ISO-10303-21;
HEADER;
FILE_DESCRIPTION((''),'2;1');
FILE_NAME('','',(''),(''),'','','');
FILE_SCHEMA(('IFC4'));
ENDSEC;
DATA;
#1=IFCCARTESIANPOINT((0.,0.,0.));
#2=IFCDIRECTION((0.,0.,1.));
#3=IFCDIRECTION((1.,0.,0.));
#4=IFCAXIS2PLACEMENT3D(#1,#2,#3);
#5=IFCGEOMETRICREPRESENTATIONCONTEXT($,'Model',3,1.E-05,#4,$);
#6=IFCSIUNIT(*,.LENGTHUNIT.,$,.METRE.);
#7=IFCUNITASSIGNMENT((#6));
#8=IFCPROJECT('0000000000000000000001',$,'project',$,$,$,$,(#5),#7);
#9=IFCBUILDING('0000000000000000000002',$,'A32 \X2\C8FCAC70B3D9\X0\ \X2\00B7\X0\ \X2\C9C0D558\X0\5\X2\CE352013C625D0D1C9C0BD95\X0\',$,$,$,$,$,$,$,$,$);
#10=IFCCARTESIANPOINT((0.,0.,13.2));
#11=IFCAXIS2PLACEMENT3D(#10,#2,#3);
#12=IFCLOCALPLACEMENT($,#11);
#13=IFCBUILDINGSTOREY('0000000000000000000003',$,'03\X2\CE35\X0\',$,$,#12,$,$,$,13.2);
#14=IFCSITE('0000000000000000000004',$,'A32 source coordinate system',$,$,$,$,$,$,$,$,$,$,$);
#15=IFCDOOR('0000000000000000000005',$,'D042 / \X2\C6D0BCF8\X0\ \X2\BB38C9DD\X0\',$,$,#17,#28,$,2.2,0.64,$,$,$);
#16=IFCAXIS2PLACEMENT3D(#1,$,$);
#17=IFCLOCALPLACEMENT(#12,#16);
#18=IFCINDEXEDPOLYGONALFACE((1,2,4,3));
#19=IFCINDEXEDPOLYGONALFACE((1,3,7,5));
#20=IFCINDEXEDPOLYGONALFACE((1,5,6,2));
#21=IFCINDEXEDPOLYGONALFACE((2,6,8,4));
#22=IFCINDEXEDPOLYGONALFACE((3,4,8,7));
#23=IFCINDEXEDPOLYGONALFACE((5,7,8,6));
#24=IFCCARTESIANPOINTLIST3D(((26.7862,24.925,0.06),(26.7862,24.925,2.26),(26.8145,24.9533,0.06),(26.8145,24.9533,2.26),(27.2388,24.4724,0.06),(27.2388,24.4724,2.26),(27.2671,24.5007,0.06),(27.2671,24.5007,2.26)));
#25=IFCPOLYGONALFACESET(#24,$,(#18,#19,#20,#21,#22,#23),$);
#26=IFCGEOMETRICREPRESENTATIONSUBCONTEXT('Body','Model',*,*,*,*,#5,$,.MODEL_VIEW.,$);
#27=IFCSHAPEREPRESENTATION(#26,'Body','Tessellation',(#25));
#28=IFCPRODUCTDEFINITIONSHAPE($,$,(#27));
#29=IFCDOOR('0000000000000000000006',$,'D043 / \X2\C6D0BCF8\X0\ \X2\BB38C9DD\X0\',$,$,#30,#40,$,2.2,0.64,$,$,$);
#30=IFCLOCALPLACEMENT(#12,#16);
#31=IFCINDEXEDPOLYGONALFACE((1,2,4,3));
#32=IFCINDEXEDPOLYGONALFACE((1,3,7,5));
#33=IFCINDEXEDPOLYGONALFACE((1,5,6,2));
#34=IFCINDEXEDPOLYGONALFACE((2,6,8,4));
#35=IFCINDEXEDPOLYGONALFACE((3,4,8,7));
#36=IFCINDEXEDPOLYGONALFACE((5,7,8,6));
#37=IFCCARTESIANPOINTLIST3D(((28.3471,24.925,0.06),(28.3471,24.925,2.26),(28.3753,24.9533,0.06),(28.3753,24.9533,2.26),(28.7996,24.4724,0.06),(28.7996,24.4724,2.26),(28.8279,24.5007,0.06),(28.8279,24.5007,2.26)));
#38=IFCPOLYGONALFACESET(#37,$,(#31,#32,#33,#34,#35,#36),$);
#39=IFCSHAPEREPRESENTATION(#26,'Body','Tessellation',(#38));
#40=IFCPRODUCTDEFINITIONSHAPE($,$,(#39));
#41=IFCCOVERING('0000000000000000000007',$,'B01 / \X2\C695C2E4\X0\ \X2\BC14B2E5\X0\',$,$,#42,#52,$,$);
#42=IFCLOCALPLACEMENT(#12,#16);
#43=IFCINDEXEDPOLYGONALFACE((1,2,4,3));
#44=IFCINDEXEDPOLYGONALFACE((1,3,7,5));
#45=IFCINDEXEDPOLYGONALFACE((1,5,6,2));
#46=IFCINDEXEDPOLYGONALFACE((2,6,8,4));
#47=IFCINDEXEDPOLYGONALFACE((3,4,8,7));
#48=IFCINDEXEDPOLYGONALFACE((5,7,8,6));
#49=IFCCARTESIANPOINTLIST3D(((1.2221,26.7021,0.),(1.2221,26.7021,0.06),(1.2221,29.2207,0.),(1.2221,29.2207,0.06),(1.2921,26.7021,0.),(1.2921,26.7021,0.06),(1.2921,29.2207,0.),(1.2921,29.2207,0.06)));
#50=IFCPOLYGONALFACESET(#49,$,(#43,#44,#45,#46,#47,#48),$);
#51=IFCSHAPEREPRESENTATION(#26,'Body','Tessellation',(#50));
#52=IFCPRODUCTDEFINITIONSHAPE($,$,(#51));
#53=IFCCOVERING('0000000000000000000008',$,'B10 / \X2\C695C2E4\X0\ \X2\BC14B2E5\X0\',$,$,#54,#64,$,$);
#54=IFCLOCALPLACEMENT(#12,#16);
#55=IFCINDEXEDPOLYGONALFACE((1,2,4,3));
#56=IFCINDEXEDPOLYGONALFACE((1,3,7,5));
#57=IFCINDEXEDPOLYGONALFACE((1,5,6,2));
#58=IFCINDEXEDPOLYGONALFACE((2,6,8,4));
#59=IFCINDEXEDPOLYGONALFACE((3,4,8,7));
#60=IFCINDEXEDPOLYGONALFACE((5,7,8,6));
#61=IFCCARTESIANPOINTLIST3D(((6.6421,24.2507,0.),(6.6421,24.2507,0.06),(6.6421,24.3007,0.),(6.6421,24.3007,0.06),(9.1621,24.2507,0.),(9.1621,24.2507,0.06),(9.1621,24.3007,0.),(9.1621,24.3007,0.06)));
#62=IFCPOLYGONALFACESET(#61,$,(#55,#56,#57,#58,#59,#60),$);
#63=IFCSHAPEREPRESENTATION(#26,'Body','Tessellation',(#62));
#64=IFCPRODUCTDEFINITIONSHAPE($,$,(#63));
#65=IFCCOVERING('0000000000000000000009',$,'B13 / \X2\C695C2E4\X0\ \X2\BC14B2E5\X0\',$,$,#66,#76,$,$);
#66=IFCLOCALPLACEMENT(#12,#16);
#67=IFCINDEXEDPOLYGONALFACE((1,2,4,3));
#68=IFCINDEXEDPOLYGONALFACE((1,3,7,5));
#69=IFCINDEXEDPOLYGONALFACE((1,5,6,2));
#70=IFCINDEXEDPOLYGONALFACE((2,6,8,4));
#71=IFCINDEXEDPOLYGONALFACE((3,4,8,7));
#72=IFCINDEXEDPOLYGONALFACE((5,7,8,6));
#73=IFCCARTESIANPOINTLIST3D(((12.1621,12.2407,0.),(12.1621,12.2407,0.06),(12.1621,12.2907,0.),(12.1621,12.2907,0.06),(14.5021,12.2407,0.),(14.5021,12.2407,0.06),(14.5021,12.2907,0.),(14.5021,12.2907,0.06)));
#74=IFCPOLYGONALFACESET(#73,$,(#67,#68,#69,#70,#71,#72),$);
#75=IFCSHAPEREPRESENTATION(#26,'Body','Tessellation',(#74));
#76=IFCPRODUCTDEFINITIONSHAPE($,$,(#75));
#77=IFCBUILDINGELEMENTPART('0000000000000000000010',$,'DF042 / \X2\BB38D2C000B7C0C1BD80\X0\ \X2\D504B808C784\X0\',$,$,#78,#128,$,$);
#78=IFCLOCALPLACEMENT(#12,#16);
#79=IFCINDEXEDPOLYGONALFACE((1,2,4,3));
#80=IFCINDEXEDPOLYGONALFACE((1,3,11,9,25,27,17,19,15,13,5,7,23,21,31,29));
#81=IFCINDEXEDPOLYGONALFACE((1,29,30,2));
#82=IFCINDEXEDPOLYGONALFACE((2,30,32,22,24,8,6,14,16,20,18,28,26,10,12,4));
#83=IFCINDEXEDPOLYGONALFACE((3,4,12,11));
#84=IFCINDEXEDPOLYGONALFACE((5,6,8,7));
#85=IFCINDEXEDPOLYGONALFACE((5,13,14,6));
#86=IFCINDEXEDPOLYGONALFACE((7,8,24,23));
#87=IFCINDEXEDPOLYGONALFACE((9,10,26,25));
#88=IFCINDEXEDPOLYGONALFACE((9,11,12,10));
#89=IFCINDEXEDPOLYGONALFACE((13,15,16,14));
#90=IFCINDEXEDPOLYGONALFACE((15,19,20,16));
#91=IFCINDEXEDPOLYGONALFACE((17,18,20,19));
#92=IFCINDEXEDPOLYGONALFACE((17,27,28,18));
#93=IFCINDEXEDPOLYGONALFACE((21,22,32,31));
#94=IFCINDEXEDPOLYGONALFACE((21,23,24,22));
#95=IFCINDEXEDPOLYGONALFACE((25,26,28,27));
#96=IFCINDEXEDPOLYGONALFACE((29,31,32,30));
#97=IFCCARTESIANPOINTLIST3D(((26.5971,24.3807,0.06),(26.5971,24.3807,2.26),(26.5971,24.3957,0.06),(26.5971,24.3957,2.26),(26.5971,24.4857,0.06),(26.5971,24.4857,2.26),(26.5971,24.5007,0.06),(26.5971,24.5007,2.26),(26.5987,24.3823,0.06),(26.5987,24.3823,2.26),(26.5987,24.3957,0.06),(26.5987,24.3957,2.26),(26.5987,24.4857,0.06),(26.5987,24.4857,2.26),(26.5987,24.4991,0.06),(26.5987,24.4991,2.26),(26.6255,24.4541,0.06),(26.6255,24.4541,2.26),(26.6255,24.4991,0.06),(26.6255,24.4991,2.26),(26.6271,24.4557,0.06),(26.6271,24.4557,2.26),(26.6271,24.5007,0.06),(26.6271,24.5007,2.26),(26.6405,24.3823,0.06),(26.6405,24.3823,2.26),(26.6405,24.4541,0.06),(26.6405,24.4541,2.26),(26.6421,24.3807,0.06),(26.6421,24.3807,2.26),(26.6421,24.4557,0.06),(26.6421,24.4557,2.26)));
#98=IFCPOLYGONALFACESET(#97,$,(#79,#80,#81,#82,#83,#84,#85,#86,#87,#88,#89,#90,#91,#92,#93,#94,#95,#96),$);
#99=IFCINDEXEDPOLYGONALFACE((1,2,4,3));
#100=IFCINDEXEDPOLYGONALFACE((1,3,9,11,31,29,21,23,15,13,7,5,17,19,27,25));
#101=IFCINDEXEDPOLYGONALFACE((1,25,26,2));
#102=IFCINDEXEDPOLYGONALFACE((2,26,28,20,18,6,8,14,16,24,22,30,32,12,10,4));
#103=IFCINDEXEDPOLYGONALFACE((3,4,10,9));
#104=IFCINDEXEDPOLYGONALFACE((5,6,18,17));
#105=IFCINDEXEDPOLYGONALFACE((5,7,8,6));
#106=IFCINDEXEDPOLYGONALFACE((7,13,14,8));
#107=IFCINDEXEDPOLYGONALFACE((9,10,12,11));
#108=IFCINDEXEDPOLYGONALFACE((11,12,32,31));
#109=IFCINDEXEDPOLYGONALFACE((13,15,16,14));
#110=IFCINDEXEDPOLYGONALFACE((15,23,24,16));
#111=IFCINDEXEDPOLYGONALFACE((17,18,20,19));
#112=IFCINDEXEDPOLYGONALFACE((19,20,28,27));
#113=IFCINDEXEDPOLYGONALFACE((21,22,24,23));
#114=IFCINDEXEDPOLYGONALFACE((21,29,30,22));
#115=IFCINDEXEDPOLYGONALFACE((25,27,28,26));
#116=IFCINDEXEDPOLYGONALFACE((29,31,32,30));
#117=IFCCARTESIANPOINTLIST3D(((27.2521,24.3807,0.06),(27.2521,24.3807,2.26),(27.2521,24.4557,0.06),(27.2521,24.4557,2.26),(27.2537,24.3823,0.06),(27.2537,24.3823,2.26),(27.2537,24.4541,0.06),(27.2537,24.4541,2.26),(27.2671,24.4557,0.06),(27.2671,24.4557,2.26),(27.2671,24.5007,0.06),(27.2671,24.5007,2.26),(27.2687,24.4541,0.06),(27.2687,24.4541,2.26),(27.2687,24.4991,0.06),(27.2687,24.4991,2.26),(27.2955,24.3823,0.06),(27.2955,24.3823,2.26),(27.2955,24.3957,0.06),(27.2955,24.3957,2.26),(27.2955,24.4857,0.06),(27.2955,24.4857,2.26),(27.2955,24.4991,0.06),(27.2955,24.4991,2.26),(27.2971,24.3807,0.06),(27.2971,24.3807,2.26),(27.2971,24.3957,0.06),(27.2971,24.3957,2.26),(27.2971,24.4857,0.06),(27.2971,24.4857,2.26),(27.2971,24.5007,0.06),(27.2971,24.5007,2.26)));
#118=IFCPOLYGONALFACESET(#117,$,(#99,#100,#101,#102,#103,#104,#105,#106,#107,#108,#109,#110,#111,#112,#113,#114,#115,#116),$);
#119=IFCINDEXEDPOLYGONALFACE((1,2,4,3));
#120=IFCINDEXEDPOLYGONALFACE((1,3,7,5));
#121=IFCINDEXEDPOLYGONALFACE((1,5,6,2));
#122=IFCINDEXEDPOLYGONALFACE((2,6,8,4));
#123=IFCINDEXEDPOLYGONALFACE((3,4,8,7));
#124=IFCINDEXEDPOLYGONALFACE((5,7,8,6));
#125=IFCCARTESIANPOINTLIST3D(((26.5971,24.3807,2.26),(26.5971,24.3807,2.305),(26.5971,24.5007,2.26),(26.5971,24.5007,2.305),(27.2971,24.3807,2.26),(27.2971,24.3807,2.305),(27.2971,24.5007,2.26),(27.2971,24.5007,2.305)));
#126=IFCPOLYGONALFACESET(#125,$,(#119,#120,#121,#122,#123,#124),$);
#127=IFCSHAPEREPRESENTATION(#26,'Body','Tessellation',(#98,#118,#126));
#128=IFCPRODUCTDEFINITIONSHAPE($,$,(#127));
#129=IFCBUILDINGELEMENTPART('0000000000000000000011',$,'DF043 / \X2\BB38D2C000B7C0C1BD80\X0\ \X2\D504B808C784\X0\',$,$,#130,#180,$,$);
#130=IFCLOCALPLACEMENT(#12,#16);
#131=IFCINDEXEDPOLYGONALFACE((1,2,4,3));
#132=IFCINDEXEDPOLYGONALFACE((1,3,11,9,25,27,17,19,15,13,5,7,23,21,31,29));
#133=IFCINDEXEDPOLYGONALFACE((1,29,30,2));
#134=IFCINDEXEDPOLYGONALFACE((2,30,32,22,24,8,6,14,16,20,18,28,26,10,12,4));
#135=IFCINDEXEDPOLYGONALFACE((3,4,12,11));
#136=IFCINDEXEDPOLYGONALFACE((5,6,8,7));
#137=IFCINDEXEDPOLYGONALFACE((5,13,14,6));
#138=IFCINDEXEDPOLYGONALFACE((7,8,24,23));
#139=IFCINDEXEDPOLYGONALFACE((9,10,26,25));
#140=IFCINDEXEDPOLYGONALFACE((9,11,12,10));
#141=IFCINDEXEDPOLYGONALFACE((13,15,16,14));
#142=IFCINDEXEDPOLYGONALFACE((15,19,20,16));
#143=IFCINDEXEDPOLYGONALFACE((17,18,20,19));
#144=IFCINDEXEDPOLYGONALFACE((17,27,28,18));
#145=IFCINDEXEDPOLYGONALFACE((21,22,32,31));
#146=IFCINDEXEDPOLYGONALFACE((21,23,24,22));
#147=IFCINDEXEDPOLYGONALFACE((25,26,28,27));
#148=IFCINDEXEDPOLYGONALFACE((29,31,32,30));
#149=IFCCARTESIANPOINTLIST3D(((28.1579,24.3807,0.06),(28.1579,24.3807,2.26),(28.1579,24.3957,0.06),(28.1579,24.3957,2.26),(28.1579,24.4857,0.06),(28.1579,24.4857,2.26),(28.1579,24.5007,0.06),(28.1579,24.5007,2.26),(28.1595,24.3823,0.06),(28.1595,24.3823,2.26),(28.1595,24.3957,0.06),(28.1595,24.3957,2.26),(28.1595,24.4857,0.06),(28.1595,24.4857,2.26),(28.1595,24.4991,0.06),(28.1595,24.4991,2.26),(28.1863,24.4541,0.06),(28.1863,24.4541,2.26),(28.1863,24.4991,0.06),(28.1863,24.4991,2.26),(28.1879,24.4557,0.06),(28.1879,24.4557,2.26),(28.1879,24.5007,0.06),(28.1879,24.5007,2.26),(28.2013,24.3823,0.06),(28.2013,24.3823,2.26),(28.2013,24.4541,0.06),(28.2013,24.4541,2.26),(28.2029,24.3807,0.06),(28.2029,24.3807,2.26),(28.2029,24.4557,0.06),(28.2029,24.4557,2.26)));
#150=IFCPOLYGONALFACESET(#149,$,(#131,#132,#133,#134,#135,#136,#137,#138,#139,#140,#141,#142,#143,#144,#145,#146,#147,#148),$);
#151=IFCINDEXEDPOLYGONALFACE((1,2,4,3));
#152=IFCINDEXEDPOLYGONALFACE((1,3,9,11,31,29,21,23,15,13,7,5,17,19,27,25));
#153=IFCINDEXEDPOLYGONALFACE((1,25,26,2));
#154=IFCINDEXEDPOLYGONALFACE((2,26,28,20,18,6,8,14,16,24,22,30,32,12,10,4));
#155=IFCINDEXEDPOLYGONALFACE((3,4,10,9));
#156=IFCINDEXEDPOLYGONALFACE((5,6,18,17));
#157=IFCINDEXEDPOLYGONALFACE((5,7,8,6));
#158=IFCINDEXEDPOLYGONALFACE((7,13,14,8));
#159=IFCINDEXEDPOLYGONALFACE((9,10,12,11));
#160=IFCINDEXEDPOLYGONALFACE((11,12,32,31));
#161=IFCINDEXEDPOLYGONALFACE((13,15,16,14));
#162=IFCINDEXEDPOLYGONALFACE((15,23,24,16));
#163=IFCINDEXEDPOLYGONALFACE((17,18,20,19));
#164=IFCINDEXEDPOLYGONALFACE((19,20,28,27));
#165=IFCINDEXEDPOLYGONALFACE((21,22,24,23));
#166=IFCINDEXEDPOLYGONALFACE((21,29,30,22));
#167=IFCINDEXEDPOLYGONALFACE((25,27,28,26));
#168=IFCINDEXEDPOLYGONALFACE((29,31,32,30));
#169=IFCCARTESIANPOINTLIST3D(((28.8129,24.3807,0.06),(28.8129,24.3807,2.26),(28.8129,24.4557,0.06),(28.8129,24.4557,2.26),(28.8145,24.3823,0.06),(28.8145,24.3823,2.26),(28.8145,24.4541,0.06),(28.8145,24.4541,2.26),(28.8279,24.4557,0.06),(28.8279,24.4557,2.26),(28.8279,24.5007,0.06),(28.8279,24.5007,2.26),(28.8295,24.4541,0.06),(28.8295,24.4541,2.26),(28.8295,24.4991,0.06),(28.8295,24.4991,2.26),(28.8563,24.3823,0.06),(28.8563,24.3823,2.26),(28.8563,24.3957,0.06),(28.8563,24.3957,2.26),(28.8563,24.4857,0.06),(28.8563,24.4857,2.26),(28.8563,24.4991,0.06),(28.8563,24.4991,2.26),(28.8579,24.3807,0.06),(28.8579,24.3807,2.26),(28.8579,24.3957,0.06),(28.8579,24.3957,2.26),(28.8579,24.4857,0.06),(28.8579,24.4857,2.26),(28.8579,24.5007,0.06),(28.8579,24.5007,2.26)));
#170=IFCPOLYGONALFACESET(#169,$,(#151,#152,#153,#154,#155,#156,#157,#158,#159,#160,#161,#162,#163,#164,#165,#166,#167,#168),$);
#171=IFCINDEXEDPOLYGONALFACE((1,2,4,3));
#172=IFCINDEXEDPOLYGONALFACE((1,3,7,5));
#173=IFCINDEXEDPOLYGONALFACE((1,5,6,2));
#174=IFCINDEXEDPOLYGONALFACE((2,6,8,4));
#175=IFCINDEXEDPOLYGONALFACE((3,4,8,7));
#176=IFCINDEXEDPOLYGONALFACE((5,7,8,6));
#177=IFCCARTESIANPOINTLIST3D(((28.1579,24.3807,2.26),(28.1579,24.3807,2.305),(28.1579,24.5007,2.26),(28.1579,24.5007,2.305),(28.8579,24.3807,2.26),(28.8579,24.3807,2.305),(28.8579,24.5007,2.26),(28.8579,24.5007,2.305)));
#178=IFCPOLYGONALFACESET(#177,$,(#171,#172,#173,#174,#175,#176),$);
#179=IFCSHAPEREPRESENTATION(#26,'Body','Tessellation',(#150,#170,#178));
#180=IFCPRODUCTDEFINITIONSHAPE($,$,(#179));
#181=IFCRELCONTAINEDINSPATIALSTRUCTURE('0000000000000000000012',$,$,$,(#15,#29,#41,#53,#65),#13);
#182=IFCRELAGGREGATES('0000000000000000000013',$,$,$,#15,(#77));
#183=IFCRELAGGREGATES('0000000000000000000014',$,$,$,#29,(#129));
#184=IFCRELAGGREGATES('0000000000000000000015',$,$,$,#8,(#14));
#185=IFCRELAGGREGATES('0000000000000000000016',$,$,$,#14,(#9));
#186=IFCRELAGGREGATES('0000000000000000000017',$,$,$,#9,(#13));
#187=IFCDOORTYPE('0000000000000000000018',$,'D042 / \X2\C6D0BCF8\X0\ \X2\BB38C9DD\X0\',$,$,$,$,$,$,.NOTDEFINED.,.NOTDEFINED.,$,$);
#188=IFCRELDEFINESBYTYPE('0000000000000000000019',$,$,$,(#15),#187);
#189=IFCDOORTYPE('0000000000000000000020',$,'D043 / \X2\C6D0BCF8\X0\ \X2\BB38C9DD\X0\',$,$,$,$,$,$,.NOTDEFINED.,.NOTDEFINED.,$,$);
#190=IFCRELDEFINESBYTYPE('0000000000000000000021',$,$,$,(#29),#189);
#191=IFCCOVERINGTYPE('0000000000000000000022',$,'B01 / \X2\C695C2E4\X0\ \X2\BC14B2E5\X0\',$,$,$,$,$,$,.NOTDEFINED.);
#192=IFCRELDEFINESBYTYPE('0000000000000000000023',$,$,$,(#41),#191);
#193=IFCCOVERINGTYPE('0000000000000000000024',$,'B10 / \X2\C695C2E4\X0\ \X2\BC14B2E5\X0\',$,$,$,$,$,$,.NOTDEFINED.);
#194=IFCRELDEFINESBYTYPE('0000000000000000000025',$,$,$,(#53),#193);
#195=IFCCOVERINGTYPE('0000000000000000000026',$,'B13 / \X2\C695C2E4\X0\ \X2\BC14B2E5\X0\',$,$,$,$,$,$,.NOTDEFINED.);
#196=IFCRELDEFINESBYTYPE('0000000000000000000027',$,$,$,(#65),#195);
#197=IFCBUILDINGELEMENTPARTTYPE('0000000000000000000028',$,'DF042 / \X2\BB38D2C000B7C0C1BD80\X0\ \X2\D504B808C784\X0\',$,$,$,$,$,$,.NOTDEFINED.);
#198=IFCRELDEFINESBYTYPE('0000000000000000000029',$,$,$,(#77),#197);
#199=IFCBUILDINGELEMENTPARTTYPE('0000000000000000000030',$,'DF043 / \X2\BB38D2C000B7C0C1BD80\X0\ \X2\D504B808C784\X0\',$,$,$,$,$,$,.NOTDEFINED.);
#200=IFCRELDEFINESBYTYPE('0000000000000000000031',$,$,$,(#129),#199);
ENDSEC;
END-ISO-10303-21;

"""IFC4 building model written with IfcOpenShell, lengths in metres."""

from ifc_helpers import new_model, si_unit, frame, origin, origin_with_axes, place, context, subcontext, project, spatial, polyline, outline, extrude, source, transform, mapped, type_object, type_shapes, element, aggregate, save


model = new_model("IFC4")

# Units and contexts
model_context = context("Model", 3, precision=1e-05, world=origin_with_axes())
body_context = subcontext(model_context, "Body", "Model", "MODEL_VIEW")
ifc_project = project(units=[si_unit("LENGTHUNIT", "METRE")], contexts=[model_context])

# Site, building, storey
site = spatial("IfcSite", under=ifc_project, Name="A32 source coordinate system")
building = spatial("IfcBuilding", under=site, Name="A32 주거동 · 지하5층–옥탑지붕")
storey_placement = place(None, frame((0.0, 0.0, 13.2), z_axis=(0.0, 0.0, 1.0), x_axis=(1.0, 0.0, 0.0)))
storey = spatial("IfcBuildingStorey", under=building, at=storey_placement, Name="03층", Elevation=13.2)

# Doors
door_type_1 = type_object("IfcDoorType", Name="D042 / 원본 문짝", OperationType="NOTDEFINED", PredefinedType="NOTDEFINED")
shared_shape_1 = source(origin(), body_context, "Body", "SweptSolid", [
    extrude(outline(polyline([(27.2671, 24.5007), (27.2388, 24.4724), (26.7862, 24.925), (26.8145, 24.9533), (27.2671, 24.5007)])), frame((0.0, 0.0, 0.06)), (0.0, 0.0, 1.0), 2.2),
])
type_shapes(door_type_1, [shared_shape_1])
door_1_placement = place(storey_placement, origin_with_axes())
door_1 = element("IfcDoor", 1, at=door_1_placement, inside=storey, type_object=door_type_1, Name="D042 / 원본 문짝", OverallHeight=2.2, OverallWidth=0.64, context=body_context, shape_type="MappedRepresentation", body=[
    mapped(shared_shape_1, transform((0.0, 0.0, 0.0), scale=1.0)),
])
door_type_2 = type_object("IfcDoorType", Name="D043 / 원본 문짝", OperationType="NOTDEFINED", PredefinedType="NOTDEFINED")
shared_shape_2 = source(origin(), body_context, "Body", "SweptSolid", [
    extrude(outline(polyline([(28.8279, 24.5007), (28.7996, 24.4724), (28.3471, 24.925), (28.3753, 24.9533), (28.8279, 24.5007)])), frame((0.0, 0.0, 0.06)), (0.0, 0.0, 1.0), 2.2),
])
type_shapes(door_type_2, [shared_shape_2])
door_2_placement = place(storey_placement, origin_with_axes())
door_2 = element("IfcDoor", 2, at=door_2_placement, inside=storey, type_object=door_type_2, Name="D043 / 원본 문짝", OverallHeight=2.2, OverallWidth=0.64, context=body_context, shape_type="MappedRepresentation", body=[
    mapped(shared_shape_2, transform((0.0, 0.0, 0.0), scale=1.0)),
])

# Coverings
covering_type_1 = type_object("IfcCoveringType", Name="B01 / 욕실 바닥", PredefinedType="NOTDEFINED")
shared_shape_3 = source(origin(), body_context, "Body", "SweptSolid", [
    extrude(outline(polyline([(1.2221, 26.7021), (1.2221, 29.2207), (1.2921, 29.2207), (1.2921, 26.7021), (1.2221, 26.7021)])), origin(), (0.0, 0.0, 1.0), 0.06),
])
type_shapes(covering_type_1, [shared_shape_3])
covering_1_placement = place(storey_placement, origin_with_axes())
element("IfcCovering", 3, at=covering_1_placement, inside=storey, type_object=covering_type_1, Name="B01 / 욕실 바닥", context=body_context, shape_type="MappedRepresentation", body=[
    mapped(shared_shape_3, transform((0.0, 0.0, 0.0), scale=1.0)),
])
covering_type_2 = type_object("IfcCoveringType", Name="B10 / 욕실 바닥", PredefinedType="NOTDEFINED")
shared_shape_4 = source(origin(), body_context, "Body", "SweptSolid", [
    extrude(outline(polyline([(9.1621, 24.3007), (9.1621, 24.2507), (6.6421, 24.2507), (6.6421, 24.3007), (9.1621, 24.3007)])), origin(), (0.0, 0.0, 1.0), 0.06),
])
type_shapes(covering_type_2, [shared_shape_4])
covering_2_placement = place(storey_placement, origin_with_axes())
element("IfcCovering", 4, at=covering_2_placement, inside=storey, type_object=covering_type_2, Name="B10 / 욕실 바닥", context=body_context, shape_type="MappedRepresentation", body=[
    mapped(shared_shape_4, transform((0.0, 0.0, 0.0), scale=1.0)),
])
covering_type_3 = type_object("IfcCoveringType", Name="B13 / 욕실 바닥", PredefinedType="NOTDEFINED")
shared_shape_5 = source(origin(), body_context, "Body", "SweptSolid", [
    extrude(outline(polyline([(12.1621, 12.2907), (14.5021, 12.2907), (14.5021, 12.2407), (12.1621, 12.2407), (12.1621, 12.2907)])), origin(), (0.0, 0.0, 1.0), 0.06),
])
type_shapes(covering_type_3, [shared_shape_5])
covering_3_placement = place(storey_placement, origin_with_axes())
element("IfcCovering", 5, at=covering_3_placement, inside=storey, type_object=covering_type_3, Name="B13 / 욕실 바닥", context=body_context, shape_type="MappedRepresentation", body=[
    mapped(shared_shape_5, transform((0.0, 0.0, 0.0), scale=1.0)),
])

# Building element parts
building_element_part_type_1 = type_object("IfcBuildingElementPartType", Name="DF042 / 문틀·상부 프레임", PredefinedType="NOTDEFINED")
shared_shape_6 = source(origin(), body_context, "Body", "SweptSolid", [
    extrude(outline(polyline([(26.5971, 24.4857), (26.5971, 24.5007), (26.6271, 24.5007), (26.6271, 24.4557), (26.6421, 24.4557), (26.6421, 24.3807), (26.5971, 24.3807), (26.5971, 24.3957), (26.5987, 24.3957), (26.5987, 24.3823), (26.6405, 24.3823), (26.6405, 24.4541), (26.6255, 24.4541), (26.6255, 24.4991), (26.5987, 24.4991), (26.5987, 24.4857), (26.5971, 24.4857)])), frame((0.0, 0.0, 0.06)), (0.0, 0.0, 1.0), 2.2),
    extrude(outline(polyline([(27.2955, 24.4991), (27.2687, 24.4991), (27.2687, 24.4541), (27.2537, 24.4541), (27.2537, 24.3823), (27.2955, 24.3823), (27.2955, 24.3957), (27.2971, 24.3957), (27.2971, 24.3807), (27.2521, 24.3807), (27.2521, 24.4557), (27.2671, 24.4557), (27.2671, 24.5007), (27.2971, 24.5007), (27.2971, 24.4857), (27.2955, 24.4857), (27.2955, 24.4991)])), frame((0.0, 0.0, 0.06)), (0.0, 0.0, 1.0), 2.2),
    extrude(outline(polyline([(26.5971, 24.3807), (26.5971, 24.5007), (27.2971, 24.5007), (27.2971, 24.3807), (26.5971, 24.3807)])), frame((0.0, 0.0, 2.26)), (0.0, 0.0, 1.0), 0.045),
])
type_shapes(building_element_part_type_1, [shared_shape_6])
building_element_part_1_placement = place(door_1_placement, origin_with_axes())
building_element_part_1 = element("IfcBuildingElementPart", 6, at=building_element_part_1_placement, type_object=building_element_part_type_1, Name="DF042 / 문틀·상부 프레임", context=body_context, shape_type="MappedRepresentation", body=[
    mapped(shared_shape_6, transform((0.0, 0.0, 0.0), scale=1.0)),
])
aggregate(door_1, [building_element_part_1])
building_element_part_type_2 = type_object("IfcBuildingElementPartType", Name="DF043 / 문틀·상부 프레임", PredefinedType="NOTDEFINED")
shared_shape_7 = source(origin(), body_context, "Body", "SweptSolid", [
    extrude(outline(polyline([(28.1579, 24.4857), (28.1579, 24.5007), (28.1879, 24.5007), (28.1879, 24.4557), (28.2029, 24.4557), (28.2029, 24.3807), (28.1579, 24.3807), (28.1579, 24.3957), (28.1595, 24.3957), (28.1595, 24.3823), (28.2013, 24.3823), (28.2013, 24.4541), (28.1863, 24.4541), (28.1863, 24.4991), (28.1595, 24.4991), (28.1595, 24.4857), (28.1579, 24.4857)])), frame((0.0, 0.0, 0.06)), (0.0, 0.0, 1.0), 2.2),
    extrude(outline(polyline([(28.8563, 24.4991), (28.8295, 24.4991), (28.8295, 24.4541), (28.8145, 24.4541), (28.8145, 24.3823), (28.8563, 24.3823), (28.8563, 24.3957), (28.8579, 24.3957), (28.8579, 24.3807), (28.8129, 24.3807), (28.8129, 24.4557), (28.8279, 24.4557), (28.8279, 24.5007), (28.8579, 24.5007), (28.8579, 24.4857), (28.8563, 24.4857), (28.8563, 24.4991)])), frame((0.0, 0.0, 0.06)), (0.0, 0.0, 1.0), 2.2),
    extrude(outline(polyline([(28.1579, 24.3807), (28.1579, 24.5007), (28.8579, 24.5007), (28.8579, 24.3807), (28.1579, 24.3807)])), frame((0.0, 0.0, 2.26)), (0.0, 0.0, 1.0), 0.045),
])
type_shapes(building_element_part_type_2, [shared_shape_7])
building_element_part_2_placement = place(door_2_placement, origin_with_axes())
building_element_part_2 = element("IfcBuildingElementPart", 7, at=building_element_part_2_placement, type_object=building_element_part_type_2, Name="DF043 / 문틀·상부 프레임", context=body_context, shape_type="MappedRepresentation", body=[
    mapped(shared_shape_7, transform((0.0, 0.0, 0.0), scale=1.0)),
])
aggregate(door_2, [building_element_part_2])

save(model, "model.ifc")
